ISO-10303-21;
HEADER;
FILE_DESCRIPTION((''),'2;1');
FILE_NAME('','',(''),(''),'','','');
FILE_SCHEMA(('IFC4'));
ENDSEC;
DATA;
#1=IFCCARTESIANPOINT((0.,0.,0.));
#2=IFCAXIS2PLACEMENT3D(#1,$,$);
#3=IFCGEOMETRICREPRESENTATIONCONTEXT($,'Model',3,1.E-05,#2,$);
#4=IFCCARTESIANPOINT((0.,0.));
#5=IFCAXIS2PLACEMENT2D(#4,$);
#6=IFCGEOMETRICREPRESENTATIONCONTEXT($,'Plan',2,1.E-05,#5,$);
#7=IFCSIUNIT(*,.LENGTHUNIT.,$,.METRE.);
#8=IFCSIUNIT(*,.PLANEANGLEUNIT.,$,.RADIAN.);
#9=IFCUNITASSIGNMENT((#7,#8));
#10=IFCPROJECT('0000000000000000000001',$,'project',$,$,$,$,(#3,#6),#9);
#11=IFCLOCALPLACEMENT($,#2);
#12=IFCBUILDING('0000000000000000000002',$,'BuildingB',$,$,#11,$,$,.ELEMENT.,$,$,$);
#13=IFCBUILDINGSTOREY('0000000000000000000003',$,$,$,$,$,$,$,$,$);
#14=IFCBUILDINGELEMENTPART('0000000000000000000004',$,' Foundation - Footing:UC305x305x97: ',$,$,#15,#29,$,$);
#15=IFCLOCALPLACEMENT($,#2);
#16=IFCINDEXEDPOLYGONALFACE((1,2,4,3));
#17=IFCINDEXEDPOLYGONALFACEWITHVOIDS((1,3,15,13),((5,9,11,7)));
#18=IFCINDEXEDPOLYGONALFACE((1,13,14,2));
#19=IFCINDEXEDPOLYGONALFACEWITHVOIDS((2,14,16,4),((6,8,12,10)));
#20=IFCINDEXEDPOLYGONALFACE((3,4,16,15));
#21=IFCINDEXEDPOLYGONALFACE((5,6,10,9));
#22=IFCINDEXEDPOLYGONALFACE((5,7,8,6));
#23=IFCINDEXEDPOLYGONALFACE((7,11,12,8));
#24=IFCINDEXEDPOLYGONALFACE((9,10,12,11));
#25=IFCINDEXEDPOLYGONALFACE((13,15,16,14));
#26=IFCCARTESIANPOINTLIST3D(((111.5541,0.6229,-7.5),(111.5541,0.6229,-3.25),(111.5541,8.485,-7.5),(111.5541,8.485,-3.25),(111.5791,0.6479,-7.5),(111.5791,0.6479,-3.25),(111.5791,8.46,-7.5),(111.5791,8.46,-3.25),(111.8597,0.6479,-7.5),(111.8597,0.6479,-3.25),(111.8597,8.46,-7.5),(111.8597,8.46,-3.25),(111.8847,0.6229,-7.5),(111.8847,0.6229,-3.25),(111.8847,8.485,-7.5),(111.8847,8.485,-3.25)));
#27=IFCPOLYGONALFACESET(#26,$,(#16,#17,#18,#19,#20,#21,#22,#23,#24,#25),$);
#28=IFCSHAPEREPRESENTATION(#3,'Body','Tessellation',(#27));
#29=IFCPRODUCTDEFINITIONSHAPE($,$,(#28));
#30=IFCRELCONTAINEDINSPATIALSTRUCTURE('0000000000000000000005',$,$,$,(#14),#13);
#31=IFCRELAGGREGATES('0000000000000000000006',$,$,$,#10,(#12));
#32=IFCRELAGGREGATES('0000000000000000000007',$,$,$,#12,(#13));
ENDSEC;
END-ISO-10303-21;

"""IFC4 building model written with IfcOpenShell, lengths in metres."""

from ifc_helpers import new_model, si_unit, origin, origin_2d, place, context, project, spatial, polyline, outline, extrude, element, save


model = new_model("IFC4")

# Units and contexts
model_context = context("Model", 3, precision=1e-05, world=origin())
plan_context = context("Plan", 2, precision=1e-05, world=origin_2d())
ifc_project = project(units=[si_unit("LENGTHUNIT", "METRE"), si_unit("PLANEANGLEUNIT", "RADIAN")], contexts=[model_context, plan_context])

# Building, storey
building_placement = place(None, origin())
building = spatial("IfcBuilding", under=ifc_project, at=building_placement, Name="BuildingB", CompositionType="ELEMENT")
storey = spatial("IfcBuildingStorey", under=building)

# Building element part, opening
building_element_part_1 = element("IfcBuildingElementPart", 1, inside=storey, Name=" Foundation - Footing:UC305x305x97: ", context=model_context, shape_type="SweptSolid", body=[
    extrude(outline(polyline([(111.8847, 0.6229, -7.5), (111.5541, 0.6229, -7.5), (111.5541, 8.485, -7.5), (111.8847, 8.485, -7.5), (111.8847, 0.6229, -7.5)])), None, (0.0, 0.0, 1.0), 4.25),
])
element("IfcOpeningElement", 2, inside=storey, cuts=building_element_part_1, context=model_context, shape_type="SweptSolid", body=[
    extrude(outline(polyline([(111.8597, 0.6479, -7.5), (111.5791, 0.6479, -7.5), (111.5791, 8.46, -7.5), (111.8597, 8.46, -7.5), (111.8597, 0.6479, -7.5)])), None, (0.0, 0.0, 1.0), 4.25),
])

save(model, "model.ifc")
